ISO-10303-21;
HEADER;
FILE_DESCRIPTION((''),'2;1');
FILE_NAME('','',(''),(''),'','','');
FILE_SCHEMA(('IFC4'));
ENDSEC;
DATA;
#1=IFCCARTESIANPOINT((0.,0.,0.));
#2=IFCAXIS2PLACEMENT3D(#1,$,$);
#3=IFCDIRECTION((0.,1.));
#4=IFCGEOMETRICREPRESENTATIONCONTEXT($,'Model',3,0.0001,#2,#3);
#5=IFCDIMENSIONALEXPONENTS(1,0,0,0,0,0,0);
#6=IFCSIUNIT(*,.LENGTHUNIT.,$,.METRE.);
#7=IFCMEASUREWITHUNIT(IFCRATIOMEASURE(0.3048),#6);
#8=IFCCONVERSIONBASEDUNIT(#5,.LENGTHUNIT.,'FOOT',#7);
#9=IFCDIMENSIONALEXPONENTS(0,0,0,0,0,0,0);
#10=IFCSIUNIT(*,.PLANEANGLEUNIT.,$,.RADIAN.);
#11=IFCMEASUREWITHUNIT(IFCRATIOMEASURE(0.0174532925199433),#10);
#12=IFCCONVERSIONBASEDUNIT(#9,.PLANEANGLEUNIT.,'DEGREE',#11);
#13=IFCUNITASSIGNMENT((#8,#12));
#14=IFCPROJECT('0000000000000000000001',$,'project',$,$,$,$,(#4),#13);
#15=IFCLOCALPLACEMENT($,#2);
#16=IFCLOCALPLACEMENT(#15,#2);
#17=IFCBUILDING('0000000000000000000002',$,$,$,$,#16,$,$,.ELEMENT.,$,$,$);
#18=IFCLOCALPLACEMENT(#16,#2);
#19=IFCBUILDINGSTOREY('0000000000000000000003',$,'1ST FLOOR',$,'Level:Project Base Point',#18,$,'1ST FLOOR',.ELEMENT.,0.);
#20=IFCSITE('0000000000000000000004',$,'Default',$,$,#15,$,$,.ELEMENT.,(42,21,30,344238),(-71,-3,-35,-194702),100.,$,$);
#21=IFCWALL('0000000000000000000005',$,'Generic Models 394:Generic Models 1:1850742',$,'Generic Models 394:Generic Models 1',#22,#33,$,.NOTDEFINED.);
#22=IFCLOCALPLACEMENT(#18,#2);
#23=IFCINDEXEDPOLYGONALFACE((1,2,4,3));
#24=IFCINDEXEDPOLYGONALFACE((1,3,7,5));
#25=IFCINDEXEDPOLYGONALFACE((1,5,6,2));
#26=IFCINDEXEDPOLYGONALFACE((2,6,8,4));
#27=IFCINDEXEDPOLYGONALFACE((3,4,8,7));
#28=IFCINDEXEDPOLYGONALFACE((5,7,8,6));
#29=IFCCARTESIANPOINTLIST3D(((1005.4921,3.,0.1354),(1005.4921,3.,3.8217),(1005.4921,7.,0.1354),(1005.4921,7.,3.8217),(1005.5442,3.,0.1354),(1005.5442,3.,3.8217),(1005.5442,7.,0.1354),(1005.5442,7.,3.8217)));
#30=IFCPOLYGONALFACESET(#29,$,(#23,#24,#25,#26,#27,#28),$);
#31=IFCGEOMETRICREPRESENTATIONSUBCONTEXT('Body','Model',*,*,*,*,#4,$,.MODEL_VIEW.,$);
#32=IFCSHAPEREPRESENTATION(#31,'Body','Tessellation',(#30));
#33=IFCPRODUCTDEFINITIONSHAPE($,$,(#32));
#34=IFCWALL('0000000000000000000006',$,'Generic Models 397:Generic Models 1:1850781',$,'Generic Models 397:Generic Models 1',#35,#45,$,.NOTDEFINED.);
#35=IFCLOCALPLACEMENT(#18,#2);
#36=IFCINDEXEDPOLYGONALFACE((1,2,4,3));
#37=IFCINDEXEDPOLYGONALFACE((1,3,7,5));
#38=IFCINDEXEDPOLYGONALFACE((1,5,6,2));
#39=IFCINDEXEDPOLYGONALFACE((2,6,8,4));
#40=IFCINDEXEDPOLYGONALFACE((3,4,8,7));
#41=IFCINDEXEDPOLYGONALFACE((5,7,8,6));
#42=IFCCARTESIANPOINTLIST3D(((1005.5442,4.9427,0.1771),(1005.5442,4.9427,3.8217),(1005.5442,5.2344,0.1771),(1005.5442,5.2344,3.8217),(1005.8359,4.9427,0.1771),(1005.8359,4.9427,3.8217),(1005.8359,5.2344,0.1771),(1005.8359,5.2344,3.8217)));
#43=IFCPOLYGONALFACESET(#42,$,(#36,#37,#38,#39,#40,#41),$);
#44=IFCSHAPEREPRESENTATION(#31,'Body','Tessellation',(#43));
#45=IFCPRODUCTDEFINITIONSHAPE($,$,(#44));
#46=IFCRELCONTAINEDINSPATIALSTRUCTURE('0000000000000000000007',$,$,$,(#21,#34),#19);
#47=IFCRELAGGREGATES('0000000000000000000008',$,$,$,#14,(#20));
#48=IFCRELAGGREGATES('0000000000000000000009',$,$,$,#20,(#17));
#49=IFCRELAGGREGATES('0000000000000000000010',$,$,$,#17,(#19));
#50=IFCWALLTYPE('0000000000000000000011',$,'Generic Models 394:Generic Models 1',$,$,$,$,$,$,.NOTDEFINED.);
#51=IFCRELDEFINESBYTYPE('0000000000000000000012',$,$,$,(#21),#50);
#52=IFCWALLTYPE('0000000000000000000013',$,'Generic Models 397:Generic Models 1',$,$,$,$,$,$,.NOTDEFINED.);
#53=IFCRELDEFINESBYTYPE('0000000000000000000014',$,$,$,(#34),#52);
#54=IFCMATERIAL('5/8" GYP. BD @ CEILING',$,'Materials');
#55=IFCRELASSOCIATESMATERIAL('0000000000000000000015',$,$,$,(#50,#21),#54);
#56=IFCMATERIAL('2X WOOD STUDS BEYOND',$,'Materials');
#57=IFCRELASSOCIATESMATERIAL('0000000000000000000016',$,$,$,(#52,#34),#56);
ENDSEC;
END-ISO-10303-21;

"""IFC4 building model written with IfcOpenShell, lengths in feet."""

from ifc_helpers import new_model, entity, si_unit, converted_unit, direction, frame, frame_2d, origin, origin_2d_with_axis, place, context, subcontext, project, spatial, rectangle, extrude, material, type_object, element, save


model = new_model("IFC4")

# Units and contexts
model_context = context("Model", 3, precision=0.0001, world=origin(), true_north=direction((0.0, 1.0)))
body_context = subcontext(model_context, "Body", "Model", "MODEL_VIEW")
ifc_project = project(units=[converted_unit("LENGTHUNIT", "FOOT", entity("IfcRatioMeasure", 0.3048), si_unit("LENGTHUNIT", "METRE"), dimensions=[1, 0, 0, 0, 0, 0, 0]), converted_unit("PLANEANGLEUNIT", "DEGREE", entity("IfcRatioMeasure", 0.0174532925199433), si_unit("PLANEANGLEUNIT", "RADIAN"), dimensions=[0, 0, 0, 0, 0, 0, 0])], contexts=[model_context])

# Site, building, storey
site_placement = place(None, origin())
site = spatial("IfcSite", under=ifc_project, at=site_placement, Name="Default", CompositionType="ELEMENT", RefLatitude=(42, 21, 30, 344238), RefLongitude=(-71, -3, -35, -194702), RefElevation=100.0)
building_placement = place(site_placement, origin())
building = spatial("IfcBuilding", under=site, at=building_placement, CompositionType="ELEMENT")
storey_placement = place(building_placement, origin())
storey = spatial("IfcBuildingStorey", under=building, at=storey_placement, Name="1ST FLOOR", ObjectType="Level:Project Base Point", LongName="1ST FLOOR", CompositionType="ELEMENT", Elevation=0.0)

# Walls
ifc_material_1 = material(Name="5/8\" GYP. BD @ CEILING", Category="Materials")
wall_type_1 = type_object("IfcWallType", Name="Generic Models 394:Generic Models 1", PredefinedType="NOTDEFINED", material=ifc_material_1)
wall_1_placement = place(storey_placement, frame((1005.4921, 3.0, 0.1354), z_axis=(0.0, 0.0, 1.0), x_axis=(0.0, 1.0, 0.0)))
element("IfcWall", 1, at=wall_1_placement, inside=storey, type_object=wall_type_1, material=ifc_material_1, Name="Generic Models 394:Generic Models 1:1850742", ObjectType="Generic Models 394:Generic Models 1", PredefinedType="NOTDEFINED", context=body_context, shape_type="SweptSolid", body=[
    extrude(rectangle(XDim=4.0, YDim=0.0521, at=frame_2d((0.0, 0.0), x_axis=(1.0, 0.0))), frame((2.0, -0.026, 0.0)), (0.0, 0.0, 1.0), 3.6863),
])
ifc_material_2 = material(Name="2X WOOD STUDS BEYOND", Category="Materials")
wall_type_2 = type_object("IfcWallType", Name="Generic Models 397:Generic Models 1", PredefinedType="NOTDEFINED", material=ifc_material_2)
wall_2_placement = place(storey_placement, frame((1005.5442, 4.9427, 0.1771)))
element("IfcWall", 2, at=wall_2_placement, inside=storey, type_object=wall_type_2, material=ifc_material_2, Name="Generic Models 397:Generic Models 1:1850781", ObjectType="Generic Models 397:Generic Models 1", PredefinedType="NOTDEFINED", context=body_context, shape_type="SweptSolid", body=[
    extrude(rectangle(XDim=0.2917, YDim=0.2917, at=origin_2d_with_axis()), frame((0.1458, 0.1458, 0.0), z_axis=(0.0, 0.0, 1.0), x_axis=(0.0, 1.0, 0.0)), (0.0, 0.0, 1.0), 3.6447),
])

save(model, "model.ifc")
